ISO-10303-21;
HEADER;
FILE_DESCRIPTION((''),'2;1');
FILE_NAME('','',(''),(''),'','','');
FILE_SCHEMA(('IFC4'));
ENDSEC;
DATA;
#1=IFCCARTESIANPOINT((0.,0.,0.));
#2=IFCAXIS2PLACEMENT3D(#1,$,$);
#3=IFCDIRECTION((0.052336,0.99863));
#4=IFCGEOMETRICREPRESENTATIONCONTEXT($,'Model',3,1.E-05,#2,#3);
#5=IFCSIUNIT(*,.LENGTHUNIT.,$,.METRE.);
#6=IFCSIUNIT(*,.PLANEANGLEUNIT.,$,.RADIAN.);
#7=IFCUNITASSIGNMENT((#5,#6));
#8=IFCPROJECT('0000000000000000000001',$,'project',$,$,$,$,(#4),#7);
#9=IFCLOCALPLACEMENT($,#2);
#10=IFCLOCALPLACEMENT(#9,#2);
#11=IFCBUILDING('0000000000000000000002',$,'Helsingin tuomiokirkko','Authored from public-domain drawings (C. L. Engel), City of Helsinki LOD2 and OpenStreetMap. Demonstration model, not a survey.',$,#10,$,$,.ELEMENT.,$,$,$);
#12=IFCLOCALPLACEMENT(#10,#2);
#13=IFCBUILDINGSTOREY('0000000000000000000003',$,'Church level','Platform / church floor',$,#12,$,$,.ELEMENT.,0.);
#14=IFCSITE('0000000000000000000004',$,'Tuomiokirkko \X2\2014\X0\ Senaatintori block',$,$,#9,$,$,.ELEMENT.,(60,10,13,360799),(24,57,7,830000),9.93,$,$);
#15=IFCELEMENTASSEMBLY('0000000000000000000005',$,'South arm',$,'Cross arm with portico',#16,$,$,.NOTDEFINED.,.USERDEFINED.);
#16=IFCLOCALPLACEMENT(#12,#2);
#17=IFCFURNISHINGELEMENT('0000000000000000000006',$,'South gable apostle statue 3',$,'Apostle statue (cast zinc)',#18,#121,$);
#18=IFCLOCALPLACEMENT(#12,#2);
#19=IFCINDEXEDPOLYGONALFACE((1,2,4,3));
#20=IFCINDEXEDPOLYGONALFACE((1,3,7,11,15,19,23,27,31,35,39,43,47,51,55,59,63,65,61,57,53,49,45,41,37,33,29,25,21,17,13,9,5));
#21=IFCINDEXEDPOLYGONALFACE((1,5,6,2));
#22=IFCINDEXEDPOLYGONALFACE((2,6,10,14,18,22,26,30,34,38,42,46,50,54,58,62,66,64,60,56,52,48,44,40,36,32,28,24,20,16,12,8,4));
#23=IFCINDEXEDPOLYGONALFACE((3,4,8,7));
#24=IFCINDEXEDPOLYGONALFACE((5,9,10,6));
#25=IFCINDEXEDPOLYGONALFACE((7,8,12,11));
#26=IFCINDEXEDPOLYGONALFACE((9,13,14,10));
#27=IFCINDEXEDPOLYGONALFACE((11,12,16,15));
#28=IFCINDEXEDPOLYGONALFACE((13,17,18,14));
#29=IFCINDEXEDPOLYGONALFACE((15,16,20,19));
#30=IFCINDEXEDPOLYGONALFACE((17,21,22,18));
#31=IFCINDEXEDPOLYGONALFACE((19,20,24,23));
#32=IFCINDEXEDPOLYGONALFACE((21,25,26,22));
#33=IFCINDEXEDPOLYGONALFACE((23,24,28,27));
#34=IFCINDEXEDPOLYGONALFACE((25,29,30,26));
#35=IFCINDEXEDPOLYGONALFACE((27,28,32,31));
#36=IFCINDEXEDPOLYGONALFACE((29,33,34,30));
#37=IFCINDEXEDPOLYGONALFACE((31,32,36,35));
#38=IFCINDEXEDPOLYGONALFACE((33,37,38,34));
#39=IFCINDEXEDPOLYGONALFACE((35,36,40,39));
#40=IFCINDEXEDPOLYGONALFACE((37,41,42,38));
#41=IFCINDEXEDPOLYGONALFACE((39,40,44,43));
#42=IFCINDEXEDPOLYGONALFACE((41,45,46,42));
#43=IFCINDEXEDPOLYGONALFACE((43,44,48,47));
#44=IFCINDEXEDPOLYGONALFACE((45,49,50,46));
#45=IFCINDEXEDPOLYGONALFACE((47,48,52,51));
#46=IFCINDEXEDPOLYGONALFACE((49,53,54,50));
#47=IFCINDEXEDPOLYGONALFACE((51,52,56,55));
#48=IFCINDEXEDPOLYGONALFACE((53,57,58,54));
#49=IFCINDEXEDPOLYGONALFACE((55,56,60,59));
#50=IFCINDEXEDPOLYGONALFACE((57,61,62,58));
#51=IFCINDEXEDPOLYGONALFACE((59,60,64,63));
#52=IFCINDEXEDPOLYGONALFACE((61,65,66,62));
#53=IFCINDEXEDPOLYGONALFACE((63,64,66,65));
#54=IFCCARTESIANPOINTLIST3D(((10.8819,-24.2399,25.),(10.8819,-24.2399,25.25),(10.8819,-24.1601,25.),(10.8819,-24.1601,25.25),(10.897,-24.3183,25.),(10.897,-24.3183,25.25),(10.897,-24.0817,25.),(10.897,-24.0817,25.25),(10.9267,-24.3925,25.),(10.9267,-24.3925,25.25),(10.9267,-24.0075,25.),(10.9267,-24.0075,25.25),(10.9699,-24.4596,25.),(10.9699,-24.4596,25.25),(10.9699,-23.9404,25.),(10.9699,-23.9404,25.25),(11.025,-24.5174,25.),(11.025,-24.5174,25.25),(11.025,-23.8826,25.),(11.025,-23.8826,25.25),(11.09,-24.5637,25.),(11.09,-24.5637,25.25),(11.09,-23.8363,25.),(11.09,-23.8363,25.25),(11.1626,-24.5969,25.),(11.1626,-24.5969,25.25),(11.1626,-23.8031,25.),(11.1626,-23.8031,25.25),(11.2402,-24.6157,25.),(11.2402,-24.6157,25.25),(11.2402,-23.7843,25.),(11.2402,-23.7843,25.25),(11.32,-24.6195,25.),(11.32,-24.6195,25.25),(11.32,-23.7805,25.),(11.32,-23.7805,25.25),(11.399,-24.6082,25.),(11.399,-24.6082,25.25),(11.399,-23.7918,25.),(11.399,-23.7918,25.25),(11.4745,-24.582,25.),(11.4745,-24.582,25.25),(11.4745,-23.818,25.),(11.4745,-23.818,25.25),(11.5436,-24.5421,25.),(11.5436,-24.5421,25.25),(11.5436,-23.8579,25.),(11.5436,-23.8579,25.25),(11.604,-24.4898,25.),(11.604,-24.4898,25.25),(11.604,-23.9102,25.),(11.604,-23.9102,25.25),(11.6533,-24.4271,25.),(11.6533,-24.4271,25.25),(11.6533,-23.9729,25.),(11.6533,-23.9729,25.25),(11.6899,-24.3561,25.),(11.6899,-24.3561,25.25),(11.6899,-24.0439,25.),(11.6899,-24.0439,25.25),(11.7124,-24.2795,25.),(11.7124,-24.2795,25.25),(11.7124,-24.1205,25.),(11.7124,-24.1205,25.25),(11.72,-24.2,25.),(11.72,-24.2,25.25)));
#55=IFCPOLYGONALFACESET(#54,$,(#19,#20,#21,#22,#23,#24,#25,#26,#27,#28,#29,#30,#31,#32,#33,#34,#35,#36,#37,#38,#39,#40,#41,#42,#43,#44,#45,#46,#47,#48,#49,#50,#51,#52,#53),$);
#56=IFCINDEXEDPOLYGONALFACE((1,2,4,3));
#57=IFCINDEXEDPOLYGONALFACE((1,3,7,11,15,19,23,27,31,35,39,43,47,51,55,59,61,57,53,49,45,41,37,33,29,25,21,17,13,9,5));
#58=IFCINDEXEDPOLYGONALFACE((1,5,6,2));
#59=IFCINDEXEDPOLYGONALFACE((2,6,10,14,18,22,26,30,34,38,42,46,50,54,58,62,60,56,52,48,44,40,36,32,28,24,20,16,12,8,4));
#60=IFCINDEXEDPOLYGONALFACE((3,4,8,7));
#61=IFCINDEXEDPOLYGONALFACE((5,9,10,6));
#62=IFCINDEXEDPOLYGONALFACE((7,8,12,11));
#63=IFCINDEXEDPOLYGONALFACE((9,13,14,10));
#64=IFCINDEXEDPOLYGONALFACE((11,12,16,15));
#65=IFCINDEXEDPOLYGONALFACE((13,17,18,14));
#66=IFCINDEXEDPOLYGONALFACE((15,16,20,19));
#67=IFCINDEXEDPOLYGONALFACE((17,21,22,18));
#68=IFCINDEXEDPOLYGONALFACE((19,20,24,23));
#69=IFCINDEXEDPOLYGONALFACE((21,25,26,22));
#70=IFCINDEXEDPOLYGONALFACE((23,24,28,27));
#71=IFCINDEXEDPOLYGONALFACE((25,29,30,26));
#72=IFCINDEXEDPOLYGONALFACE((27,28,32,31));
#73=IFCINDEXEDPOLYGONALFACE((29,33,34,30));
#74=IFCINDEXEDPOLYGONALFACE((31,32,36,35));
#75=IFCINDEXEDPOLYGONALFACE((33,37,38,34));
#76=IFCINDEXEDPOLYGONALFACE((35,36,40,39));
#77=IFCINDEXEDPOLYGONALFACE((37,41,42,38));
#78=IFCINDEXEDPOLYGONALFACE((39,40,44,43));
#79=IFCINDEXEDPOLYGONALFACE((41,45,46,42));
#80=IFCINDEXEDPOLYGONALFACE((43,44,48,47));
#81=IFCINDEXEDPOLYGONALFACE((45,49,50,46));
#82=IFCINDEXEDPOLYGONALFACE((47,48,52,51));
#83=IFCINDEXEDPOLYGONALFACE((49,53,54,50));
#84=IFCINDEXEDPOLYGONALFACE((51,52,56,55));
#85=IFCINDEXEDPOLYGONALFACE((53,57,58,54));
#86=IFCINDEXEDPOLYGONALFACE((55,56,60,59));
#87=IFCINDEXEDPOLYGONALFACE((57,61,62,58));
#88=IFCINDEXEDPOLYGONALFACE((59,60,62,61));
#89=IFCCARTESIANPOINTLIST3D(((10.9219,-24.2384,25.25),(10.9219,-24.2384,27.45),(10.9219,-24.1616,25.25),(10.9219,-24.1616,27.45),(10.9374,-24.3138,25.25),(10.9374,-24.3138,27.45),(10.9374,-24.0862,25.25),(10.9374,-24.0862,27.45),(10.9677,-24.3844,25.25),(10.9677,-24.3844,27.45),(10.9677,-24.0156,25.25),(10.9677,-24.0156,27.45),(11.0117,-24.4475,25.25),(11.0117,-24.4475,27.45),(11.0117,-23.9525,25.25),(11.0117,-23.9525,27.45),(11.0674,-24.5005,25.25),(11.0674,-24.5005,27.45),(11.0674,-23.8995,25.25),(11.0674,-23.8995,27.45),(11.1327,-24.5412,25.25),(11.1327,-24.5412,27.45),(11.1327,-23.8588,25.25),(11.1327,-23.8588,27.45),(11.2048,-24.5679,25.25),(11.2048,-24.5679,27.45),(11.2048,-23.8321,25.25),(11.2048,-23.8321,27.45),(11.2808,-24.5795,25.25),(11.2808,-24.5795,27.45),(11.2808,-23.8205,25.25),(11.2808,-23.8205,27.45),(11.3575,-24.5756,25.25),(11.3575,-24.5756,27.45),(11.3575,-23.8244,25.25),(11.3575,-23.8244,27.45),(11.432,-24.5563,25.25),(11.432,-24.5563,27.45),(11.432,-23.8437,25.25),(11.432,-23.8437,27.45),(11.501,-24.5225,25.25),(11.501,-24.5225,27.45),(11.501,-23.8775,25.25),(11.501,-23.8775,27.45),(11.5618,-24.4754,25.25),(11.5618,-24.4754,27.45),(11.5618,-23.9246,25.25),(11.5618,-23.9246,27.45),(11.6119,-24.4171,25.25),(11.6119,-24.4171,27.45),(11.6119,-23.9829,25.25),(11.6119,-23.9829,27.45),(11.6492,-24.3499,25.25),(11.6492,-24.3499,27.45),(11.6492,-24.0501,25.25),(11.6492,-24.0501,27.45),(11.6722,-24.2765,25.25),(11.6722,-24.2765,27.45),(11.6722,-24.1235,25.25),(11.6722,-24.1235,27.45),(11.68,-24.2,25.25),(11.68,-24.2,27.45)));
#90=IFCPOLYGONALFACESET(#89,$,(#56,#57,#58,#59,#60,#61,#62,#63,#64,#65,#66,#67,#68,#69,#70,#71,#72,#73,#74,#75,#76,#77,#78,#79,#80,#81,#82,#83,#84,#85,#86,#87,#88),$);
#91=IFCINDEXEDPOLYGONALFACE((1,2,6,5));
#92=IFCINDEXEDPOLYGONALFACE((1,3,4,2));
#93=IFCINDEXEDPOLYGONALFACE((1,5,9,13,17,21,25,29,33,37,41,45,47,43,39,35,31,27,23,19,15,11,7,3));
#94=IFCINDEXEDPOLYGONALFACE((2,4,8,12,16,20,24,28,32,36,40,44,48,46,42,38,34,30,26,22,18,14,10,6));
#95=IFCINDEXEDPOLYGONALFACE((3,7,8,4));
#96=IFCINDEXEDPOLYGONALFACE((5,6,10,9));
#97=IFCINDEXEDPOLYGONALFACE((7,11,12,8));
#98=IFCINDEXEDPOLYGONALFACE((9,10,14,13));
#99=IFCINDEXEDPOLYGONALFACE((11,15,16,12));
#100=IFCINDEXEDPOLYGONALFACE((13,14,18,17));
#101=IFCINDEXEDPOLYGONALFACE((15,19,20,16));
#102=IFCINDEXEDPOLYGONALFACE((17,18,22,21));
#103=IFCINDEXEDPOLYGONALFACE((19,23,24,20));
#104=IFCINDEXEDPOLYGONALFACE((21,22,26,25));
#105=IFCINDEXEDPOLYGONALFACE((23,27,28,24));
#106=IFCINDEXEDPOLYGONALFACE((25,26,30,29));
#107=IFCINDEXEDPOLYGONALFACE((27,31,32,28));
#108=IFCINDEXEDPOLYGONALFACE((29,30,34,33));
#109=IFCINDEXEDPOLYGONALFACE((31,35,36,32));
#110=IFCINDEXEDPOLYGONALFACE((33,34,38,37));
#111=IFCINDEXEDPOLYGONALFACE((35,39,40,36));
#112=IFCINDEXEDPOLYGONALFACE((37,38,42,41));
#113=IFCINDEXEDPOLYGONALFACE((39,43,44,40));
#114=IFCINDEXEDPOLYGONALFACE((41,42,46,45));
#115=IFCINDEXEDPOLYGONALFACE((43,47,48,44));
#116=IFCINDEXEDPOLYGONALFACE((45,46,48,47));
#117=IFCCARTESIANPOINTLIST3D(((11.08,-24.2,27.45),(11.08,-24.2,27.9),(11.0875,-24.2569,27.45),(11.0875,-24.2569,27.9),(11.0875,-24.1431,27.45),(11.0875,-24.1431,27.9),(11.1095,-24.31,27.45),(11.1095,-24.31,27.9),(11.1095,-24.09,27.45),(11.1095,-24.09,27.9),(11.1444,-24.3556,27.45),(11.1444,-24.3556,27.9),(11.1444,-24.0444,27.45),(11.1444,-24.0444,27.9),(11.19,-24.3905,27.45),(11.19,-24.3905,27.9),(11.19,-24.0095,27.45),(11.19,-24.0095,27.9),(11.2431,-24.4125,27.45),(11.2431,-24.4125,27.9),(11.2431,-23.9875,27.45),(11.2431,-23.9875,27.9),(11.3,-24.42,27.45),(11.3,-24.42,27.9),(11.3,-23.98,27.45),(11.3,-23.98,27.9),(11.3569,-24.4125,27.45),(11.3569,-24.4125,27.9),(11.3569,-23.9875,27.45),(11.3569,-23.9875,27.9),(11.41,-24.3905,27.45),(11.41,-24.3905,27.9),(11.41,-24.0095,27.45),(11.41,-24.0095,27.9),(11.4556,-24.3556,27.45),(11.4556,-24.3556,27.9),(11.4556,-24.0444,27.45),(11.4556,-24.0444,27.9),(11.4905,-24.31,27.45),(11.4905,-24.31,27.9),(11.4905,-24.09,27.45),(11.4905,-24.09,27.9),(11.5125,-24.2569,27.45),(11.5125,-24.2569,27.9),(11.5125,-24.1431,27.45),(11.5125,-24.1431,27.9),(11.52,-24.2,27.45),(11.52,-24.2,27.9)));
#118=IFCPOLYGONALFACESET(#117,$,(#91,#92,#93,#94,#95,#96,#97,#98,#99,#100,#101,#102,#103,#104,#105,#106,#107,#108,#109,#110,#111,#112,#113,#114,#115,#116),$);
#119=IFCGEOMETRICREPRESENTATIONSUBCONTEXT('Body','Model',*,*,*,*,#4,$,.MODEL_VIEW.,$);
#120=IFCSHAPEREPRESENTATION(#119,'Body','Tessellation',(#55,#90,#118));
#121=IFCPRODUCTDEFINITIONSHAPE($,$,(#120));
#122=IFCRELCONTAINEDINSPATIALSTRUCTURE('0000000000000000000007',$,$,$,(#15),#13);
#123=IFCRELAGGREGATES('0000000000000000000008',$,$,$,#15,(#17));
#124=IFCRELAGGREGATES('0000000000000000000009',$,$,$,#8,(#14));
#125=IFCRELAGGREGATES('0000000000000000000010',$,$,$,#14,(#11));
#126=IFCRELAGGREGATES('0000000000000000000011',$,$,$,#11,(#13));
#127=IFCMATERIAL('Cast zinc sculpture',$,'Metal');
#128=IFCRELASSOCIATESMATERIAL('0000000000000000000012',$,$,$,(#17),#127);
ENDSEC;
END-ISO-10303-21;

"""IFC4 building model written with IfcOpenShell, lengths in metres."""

from ifc_helpers import new_model, si_unit, direction, frame, origin, origin_2d_with_axis, place, context, subcontext, project, spatial, circle, extrude, material, element, aggregate, save


model = new_model("IFC4")

# Units and contexts
model_context = context("Model", 3, precision=1e-05, world=origin(), true_north=direction((0.052336, 0.99863)))
body_context = subcontext(model_context, "Body", "Model", "MODEL_VIEW")
ifc_project = project(units=[si_unit("LENGTHUNIT", "METRE"), si_unit("PLANEANGLEUNIT", "RADIAN")], contexts=[model_context])

# Site, building, storey
site_placement = place(None, origin())
site = spatial("IfcSite", under=ifc_project, at=site_placement, Name="Tuomiokirkko — Senaatintori block", CompositionType="ELEMENT", RefLatitude=(60, 10, 13, 360799), RefLongitude=(24, 57, 7, 830000), RefElevation=9.93)
building_placement = place(site_placement, origin())
building = spatial("IfcBuilding", under=site, at=building_placement, Name="Helsingin tuomiokirkko", Description="Authored from public-domain drawings (C. L. Engel), City of Helsinki LOD2 and OpenStreetMap. Demonstration model, not a survey.", CompositionType="ELEMENT")
storey_placement = place(building_placement, origin())
storey = spatial("IfcBuildingStorey", under=building, at=storey_placement, Name="Church level", Description="Platform / church floor", CompositionType="ELEMENT", Elevation=0.0)

# Element assembly
assembly_1_placement = place(building_placement, origin())
assembly_1 = element("IfcElementAssembly", 1, at=assembly_1_placement, inside=storey, Name="South arm", ObjectType="Cross arm with portico", AssemblyPlace="NOTDEFINED", PredefinedType="USERDEFINED")

# Furnishing element
ifc_material_1 = material(Name="Cast zinc sculpture", Category="Metal")
furnishing_1_placement = place(building_placement, origin())
furnishing_1 = element("IfcFurnishingElement", 2, at=furnishing_1_placement, material=ifc_material_1, Name="South gable apostle statue 3", ObjectType="Apostle statue (cast zinc)", context=body_context, shape_type="SweptSolid", body=[
    extrude(circle(Radius=0.42, at=origin_2d_with_axis()), frame((11.3, -24.2, 25.0)), (0.0, 0.0, 1.0), 0.25),
    extrude(circle(Radius=0.38, at=origin_2d_with_axis()), frame((11.3, -24.2, 25.25)), (0.0, 0.0, 1.0), 2.2),
    extrude(circle(Radius=0.22, at=origin_2d_with_axis()), frame((11.3, -24.2, 27.45)), (0.0, 0.0, 1.0), 0.45),
])
aggregate(assembly_1, [furnishing_1])

save(model, "model.ifc")
